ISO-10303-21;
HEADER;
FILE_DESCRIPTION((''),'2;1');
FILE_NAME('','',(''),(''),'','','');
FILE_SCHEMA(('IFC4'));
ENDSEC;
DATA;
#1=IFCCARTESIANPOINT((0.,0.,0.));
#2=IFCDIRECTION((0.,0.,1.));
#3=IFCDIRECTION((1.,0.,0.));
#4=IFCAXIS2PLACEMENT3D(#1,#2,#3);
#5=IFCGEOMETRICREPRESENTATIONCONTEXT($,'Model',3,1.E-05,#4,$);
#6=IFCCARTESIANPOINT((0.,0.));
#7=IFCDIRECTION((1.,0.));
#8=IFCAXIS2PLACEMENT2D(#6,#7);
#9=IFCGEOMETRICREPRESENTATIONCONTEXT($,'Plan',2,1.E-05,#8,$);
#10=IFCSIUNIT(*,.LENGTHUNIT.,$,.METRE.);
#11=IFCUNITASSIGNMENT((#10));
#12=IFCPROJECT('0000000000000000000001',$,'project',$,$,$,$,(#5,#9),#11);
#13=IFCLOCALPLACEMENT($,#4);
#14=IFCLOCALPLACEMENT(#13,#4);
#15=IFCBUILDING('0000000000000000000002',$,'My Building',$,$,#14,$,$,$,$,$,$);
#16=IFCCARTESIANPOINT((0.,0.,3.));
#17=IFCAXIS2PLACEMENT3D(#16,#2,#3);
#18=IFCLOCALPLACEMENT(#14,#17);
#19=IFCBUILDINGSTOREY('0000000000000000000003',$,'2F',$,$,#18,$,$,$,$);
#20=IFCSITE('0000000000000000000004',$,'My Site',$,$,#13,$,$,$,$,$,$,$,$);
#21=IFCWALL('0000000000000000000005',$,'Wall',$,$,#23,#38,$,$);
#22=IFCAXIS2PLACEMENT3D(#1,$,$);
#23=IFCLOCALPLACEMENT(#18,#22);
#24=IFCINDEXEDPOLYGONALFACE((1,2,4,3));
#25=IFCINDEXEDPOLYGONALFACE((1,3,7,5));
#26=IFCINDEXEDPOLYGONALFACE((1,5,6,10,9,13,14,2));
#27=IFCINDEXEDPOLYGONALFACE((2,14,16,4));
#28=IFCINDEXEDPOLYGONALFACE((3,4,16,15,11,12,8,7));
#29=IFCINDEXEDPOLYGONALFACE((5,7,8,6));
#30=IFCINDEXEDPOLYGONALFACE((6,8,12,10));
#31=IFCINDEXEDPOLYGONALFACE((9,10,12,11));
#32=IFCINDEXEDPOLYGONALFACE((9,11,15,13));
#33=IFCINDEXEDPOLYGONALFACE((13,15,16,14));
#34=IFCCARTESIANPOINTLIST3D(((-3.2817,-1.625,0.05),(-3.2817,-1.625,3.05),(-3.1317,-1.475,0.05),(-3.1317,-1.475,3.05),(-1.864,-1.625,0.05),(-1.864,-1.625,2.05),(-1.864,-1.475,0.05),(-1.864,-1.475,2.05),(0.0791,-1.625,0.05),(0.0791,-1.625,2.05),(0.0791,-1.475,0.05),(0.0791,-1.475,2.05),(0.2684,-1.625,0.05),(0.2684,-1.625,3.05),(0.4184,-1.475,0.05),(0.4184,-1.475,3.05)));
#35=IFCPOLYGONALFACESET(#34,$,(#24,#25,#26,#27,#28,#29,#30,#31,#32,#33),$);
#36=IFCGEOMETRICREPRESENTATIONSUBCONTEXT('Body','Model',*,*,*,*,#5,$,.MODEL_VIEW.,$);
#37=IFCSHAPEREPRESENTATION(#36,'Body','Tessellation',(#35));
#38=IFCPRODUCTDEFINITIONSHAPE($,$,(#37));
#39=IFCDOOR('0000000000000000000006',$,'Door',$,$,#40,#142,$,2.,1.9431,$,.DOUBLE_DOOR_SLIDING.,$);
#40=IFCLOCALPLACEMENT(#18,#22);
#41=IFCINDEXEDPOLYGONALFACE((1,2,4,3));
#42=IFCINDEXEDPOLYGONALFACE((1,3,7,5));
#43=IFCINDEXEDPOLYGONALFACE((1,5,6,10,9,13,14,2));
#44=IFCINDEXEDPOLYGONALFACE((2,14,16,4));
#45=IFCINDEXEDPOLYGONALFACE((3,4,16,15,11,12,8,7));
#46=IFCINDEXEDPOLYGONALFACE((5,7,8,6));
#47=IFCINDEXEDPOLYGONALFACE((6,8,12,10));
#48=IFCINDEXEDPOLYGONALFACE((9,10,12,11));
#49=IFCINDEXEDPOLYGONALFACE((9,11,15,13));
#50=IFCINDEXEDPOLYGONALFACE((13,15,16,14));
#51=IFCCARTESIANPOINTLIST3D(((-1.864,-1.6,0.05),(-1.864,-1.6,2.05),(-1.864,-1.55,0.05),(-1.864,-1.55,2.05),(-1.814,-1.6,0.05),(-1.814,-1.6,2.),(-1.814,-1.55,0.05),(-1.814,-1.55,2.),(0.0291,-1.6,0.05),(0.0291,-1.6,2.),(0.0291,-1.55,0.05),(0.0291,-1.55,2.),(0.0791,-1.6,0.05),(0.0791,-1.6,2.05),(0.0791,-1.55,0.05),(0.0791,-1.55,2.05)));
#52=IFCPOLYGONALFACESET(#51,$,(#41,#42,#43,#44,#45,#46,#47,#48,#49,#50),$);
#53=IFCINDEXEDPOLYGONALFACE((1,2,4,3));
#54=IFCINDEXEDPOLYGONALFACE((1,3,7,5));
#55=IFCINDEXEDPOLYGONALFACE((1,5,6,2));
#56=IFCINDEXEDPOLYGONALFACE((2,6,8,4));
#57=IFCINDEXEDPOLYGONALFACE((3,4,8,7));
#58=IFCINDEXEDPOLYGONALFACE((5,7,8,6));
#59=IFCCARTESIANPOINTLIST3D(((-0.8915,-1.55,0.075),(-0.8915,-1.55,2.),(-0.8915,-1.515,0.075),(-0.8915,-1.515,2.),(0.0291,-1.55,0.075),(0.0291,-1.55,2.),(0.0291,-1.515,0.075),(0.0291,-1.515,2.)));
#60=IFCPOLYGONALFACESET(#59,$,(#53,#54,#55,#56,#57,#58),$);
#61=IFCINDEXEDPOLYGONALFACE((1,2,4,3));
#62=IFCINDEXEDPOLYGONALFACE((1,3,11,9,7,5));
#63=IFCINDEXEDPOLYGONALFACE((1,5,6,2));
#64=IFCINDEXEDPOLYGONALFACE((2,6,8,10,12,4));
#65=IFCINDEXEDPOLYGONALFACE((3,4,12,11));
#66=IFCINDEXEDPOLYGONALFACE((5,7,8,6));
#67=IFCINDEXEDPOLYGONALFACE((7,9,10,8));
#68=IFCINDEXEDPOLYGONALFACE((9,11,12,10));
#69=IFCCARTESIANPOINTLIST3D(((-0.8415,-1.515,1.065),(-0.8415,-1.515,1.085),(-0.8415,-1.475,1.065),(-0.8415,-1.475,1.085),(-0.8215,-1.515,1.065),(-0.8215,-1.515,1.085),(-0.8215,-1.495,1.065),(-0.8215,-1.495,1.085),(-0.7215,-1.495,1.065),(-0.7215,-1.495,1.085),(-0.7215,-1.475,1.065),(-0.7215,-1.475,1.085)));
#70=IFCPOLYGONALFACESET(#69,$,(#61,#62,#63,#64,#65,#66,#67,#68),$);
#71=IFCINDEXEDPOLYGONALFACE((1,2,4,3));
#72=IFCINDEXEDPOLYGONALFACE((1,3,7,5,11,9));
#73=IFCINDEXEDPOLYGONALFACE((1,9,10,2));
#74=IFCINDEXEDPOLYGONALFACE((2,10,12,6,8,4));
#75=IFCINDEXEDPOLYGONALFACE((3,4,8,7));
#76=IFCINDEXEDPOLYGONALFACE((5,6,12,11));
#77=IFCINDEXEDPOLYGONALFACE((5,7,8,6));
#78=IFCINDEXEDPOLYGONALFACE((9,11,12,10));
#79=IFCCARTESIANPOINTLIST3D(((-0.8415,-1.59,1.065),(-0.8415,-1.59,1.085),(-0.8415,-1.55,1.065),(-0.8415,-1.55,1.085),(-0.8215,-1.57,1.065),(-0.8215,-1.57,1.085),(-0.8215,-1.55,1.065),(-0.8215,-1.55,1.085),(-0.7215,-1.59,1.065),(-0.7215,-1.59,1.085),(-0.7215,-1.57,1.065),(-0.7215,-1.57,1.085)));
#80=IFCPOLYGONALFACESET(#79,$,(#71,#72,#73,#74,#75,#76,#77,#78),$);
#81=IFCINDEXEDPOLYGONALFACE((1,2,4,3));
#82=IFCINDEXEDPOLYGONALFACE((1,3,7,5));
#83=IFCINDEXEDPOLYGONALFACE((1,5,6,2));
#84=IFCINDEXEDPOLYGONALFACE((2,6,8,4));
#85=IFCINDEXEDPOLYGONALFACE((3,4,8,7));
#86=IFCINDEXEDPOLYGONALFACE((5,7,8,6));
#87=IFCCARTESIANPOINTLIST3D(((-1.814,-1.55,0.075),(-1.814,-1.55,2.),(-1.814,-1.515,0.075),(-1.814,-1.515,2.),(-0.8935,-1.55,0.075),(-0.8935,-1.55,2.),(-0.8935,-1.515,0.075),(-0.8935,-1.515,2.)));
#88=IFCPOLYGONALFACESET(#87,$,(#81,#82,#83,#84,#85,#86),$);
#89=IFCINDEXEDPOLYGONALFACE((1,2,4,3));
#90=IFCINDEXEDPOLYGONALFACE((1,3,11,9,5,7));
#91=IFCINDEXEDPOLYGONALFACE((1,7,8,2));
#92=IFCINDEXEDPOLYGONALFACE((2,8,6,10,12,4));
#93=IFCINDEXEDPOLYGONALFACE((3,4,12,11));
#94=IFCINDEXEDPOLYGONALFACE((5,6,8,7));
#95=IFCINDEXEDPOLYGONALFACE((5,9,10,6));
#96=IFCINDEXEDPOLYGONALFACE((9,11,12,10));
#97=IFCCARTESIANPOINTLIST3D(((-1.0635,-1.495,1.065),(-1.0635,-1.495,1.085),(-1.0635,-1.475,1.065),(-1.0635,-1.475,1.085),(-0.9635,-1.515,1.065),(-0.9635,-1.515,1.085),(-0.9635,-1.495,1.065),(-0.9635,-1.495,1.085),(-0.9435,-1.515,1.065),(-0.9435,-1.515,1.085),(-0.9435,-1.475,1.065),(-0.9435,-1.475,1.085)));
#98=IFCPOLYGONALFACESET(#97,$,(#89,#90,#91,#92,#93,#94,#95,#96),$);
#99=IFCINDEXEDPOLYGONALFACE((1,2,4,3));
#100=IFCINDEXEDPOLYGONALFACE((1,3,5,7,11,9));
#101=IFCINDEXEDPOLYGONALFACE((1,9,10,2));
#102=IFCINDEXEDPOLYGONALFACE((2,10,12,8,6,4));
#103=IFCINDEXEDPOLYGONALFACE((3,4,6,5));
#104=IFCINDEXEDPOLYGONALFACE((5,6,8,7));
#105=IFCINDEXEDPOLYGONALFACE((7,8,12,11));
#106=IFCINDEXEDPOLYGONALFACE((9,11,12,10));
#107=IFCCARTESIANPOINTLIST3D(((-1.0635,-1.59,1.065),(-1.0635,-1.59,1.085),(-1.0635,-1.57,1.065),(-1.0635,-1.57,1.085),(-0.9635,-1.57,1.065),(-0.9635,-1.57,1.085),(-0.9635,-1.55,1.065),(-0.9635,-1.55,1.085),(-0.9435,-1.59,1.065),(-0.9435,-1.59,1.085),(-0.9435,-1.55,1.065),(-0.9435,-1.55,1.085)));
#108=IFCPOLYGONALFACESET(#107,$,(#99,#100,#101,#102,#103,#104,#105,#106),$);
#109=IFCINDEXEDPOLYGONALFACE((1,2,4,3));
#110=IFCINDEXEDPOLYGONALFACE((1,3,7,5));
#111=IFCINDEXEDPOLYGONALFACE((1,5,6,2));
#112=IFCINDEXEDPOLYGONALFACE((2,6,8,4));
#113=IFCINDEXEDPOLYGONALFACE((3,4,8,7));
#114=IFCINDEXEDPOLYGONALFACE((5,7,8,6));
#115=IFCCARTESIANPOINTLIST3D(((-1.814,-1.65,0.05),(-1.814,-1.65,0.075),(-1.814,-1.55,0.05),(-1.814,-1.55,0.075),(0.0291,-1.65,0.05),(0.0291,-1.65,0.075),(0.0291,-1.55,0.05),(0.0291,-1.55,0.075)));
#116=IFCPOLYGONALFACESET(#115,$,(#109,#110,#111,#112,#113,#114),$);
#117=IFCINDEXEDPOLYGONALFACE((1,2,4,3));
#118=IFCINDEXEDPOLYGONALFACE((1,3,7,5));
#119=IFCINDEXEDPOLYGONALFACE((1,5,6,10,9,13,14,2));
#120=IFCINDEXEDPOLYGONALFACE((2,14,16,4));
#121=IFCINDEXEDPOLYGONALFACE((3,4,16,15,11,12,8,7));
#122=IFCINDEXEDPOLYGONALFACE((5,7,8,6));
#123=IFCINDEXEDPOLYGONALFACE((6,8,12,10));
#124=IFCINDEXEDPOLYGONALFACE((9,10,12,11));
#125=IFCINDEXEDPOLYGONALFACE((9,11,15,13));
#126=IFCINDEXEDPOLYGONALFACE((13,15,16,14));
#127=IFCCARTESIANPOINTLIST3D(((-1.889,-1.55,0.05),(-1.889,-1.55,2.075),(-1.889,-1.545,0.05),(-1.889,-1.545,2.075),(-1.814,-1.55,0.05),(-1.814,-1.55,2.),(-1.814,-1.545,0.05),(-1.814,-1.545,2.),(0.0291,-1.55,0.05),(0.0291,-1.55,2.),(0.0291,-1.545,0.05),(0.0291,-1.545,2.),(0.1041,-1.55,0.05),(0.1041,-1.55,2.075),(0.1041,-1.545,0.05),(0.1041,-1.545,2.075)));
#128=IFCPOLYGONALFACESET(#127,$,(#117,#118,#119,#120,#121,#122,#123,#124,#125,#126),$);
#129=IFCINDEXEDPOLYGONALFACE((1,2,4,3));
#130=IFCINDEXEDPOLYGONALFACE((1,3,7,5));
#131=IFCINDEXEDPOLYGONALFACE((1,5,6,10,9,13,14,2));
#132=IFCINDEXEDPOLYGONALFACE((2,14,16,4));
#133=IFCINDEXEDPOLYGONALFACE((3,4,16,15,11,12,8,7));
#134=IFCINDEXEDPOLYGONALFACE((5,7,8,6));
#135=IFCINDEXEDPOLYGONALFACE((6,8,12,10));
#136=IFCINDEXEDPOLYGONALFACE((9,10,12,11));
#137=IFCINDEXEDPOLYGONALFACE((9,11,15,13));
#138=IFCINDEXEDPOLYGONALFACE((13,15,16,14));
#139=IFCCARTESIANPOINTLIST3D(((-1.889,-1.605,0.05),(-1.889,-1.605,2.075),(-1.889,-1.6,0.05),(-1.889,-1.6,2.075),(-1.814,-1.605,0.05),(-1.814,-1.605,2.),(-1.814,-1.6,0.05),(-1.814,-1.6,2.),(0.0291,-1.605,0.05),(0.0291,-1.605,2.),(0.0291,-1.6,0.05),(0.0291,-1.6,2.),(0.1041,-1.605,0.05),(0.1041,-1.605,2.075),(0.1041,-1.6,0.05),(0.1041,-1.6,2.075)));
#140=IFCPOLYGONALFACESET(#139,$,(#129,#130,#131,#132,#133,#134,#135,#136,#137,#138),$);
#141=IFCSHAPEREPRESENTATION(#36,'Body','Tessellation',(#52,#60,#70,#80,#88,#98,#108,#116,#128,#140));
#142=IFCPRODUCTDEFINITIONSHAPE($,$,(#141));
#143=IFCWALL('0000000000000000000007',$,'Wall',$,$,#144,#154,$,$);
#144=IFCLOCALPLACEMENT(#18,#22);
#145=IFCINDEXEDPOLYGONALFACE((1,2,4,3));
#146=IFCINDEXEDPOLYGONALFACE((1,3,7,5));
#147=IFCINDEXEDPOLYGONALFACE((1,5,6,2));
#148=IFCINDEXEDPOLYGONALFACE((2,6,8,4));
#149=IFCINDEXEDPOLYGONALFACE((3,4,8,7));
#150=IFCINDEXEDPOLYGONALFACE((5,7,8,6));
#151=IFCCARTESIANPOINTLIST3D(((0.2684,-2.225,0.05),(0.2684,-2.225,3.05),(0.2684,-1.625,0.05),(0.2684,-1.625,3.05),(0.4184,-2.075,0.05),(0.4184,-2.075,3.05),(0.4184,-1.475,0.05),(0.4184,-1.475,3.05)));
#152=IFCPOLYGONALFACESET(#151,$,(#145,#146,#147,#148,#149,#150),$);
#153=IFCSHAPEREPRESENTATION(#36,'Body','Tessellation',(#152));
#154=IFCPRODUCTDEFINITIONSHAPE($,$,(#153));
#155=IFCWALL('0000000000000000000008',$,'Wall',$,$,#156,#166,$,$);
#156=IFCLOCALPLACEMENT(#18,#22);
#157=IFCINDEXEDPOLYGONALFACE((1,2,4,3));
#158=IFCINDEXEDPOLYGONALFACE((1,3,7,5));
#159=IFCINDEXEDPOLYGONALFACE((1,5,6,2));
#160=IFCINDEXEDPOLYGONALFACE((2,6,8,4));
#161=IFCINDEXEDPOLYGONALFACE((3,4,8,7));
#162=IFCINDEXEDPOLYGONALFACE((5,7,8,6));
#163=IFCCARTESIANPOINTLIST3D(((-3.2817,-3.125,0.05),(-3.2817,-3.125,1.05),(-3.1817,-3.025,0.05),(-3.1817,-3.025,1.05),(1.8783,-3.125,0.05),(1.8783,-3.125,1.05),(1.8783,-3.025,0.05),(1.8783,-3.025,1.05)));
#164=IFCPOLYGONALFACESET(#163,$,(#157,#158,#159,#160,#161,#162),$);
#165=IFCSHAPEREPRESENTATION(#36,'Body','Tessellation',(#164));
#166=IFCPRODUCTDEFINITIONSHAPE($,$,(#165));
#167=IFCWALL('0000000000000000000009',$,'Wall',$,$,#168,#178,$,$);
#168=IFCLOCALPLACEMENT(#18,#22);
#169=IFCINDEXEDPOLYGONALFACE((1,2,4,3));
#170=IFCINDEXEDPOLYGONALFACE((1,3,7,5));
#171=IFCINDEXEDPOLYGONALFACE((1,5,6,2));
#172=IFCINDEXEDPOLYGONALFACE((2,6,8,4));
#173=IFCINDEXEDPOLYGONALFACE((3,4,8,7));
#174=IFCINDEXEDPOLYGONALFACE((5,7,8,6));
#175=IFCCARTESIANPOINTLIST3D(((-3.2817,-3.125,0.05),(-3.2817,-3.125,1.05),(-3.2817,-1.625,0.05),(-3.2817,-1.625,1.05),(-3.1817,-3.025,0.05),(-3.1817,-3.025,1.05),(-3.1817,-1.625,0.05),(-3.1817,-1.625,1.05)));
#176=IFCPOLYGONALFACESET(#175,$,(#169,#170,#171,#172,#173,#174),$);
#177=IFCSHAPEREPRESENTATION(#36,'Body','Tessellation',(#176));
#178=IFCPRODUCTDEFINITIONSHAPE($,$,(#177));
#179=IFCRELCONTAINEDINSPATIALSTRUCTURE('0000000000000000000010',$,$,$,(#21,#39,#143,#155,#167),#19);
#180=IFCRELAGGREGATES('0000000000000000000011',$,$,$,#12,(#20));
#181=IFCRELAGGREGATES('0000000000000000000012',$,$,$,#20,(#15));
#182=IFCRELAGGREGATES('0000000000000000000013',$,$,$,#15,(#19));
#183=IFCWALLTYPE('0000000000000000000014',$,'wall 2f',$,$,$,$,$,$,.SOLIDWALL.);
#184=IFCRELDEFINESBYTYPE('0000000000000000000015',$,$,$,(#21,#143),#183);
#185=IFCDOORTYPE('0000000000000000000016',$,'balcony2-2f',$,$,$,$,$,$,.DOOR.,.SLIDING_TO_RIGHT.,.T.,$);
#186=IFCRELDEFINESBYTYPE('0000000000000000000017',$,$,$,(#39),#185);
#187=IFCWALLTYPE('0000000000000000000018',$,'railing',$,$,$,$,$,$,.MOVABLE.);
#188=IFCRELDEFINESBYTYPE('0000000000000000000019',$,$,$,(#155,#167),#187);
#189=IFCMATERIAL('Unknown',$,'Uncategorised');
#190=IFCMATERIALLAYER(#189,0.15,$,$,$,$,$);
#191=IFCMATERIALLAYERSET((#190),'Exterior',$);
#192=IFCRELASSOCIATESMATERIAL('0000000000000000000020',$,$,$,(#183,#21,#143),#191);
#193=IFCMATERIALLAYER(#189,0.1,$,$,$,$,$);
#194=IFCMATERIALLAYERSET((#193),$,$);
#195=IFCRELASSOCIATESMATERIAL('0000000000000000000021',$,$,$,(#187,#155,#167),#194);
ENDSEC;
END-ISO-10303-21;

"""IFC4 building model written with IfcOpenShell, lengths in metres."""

from ifc_helpers import new_model, entity, si_unit, frame, origin_with_axes, origin_2d_with_axis, place, context, subcontext, project, spatial, line, indexed_curve, outline, extrude, shape, source, transform, mapped, material, layer, layer_set, layer_usage, type_object, type_shapes, element, fill, save


model = new_model("IFC4")

# Units and contexts
model_context = context("Model", 3, precision=1e-05, world=origin_with_axes())
plan_context = context("Plan", 2, precision=1e-05, world=origin_2d_with_axis())
body_context_1 = subcontext(model_context, "Body", "Model", "MODEL_VIEW")
body_context_2 = subcontext(plan_context, "Body", "Plan", "PLAN_VIEW")
ifc_project = project(units=[si_unit("LENGTHUNIT", "METRE")], contexts=[model_context, plan_context])

# Site, building, storey
site_placement = place(None, origin_with_axes())
site = spatial("IfcSite", under=ifc_project, at=site_placement, Name="My Site")
building_placement = place(site_placement, origin_with_axes())
building = spatial("IfcBuilding", under=site, at=building_placement, Name="My Building")
storey_placement = place(building_placement, frame((0.0, 0.0, 3.0), z_axis=(0.0, 0.0, 1.0), x_axis=(1.0, 0.0, 0.0)))
storey = spatial("IfcBuildingStorey", under=building, at=storey_placement, Name="2F")

# Shared definitions
ifc_material = material(Name="Unknown", Category="Uncategorised")
ifc_layer_1 = layer(ifc_material, 0.15)
ifc_layer_set_1 = layer_set([ifc_layer_1], Name="Exterior")
wall_type_1 = type_object("IfcWallType", Name="wall 2f", PredefinedType="SOLIDWALL", material=ifc_layer_set_1)

# Wall, opening, door
ifc_layer_usage_1 = layer_usage(ifc_layer_set_1, "AXIS2", "POSITIVE", 0.0)
wall_1_placement = place(storey_placement, frame((-3.2817, -1.625, 0.05), z_axis=(0.0, 0.0, 1.0), x_axis=(1.0, 0.0, 0.0)))
wall_1 = element("IfcWall", 1, at=wall_1_placement, inside=storey, type_object=wall_type_1, material=ifc_layer_usage_1, Name="Wall", context=body_context_1, shape_type="SweptSolid", body=[
    extrude(outline(indexed_curve([(0.0, 0.0), (0.15, 0.15), (3.7, 0.15), (3.55, 0.0)], segments=[line(1, 2, 3, 4, 1)])), origin_with_axes(), (0.0, 0.0, 1.0), 3.0),
])
shared_shape_1 = source(origin_with_axes(), body_context_1, "Body", "SweptSolid", [
    extrude(outline(indexed_curve([(0.0, 0.0), (1.9431, 0.0), (1.9431, 2.0), (0.0, 2.0)], segments=[line(1, 2, 3, 4, 1)])), frame((0.0, -0.6, 0.0), z_axis=(0.0, -1.0, 0.0), x_axis=(1.0, 0.0, 0.0)), (0.0, 0.0, -1.0), 1.2),
])
opening_1_placement = place(wall_1_placement, frame((3.3607, 0.075, 0.0), z_axis=(0.0, 0.0, 1.0), x_axis=(-1.0, 0.0, 0.0)))
opening_1 = element("IfcOpeningElement", 2, at=opening_1_placement, cuts=wall_1, PredefinedType="OPENING", context=body_context_1, shape_type="MappedRepresentation", body=[
    mapped(shared_shape_1, transform((0.0, 0.0, 0.0), x_axis=(1.0, 0.0, 0.0), y_axis=(0.0, 1.0, 0.0), z_axis=(0.0, 0.0, 1.0), scale=1.0)),
])
door_type_1 = type_object("IfcDoorType", Name="balcony2-2f", OperationType="SLIDING_TO_RIGHT", ParameterTakesPrecedence=True, PredefinedType="DOOR")
shared_shape_2 = source(origin_with_axes(), body_context_1, "Body", "SweptSolid", [
    extrude(outline(indexed_curve([(0.0, 0.0), (0.0, 2.0), (1.9431, 2.0), (1.9431, 0.0), (1.8931, 0.0), (1.8931, 1.95), (0.05, 1.95), (0.05, 0.0)], segments=[line(1, 2, 3, 4, 5, 6, 7, 8, 1)])), frame((0.0, 0.0, 0.0), z_axis=(0.0, -1.0, 0.0), x_axis=(1.0, 0.0, 0.0)), (0.0, 0.0, -1.0), 0.05),
    extrude(outline(indexed_curve([(0.0, 0.0), (0.9205, 0.0), (0.9205, 0.035), (0.0, 0.035)], segments=[line(1, 2, 3, 4, 1)])), frame((0.05, -0.035, 0.025), z_axis=(0.0, 0.0, 1.0), x_axis=(1.0, 0.0, 0.0)), (0.0, 0.0, 1.0), 1.925),
    extrude(outline(indexed_curve([(0.0, 0.0), (0.0, -0.04), (-0.12, -0.04), (-0.12, -0.02), (-0.02, -0.02), (-0.02, 0.0)], segments=[line(1, 2, 3, 4, 5, 6, 1)])), frame((0.9205, -0.035, 1.015), z_axis=(0.0, 0.0, 1.0), x_axis=(1.0, 0.0, 0.0)), (0.0, 0.0, 1.0), 0.02),
    extrude(outline(indexed_curve([(0.0, 0.0), (0.0, 0.04), (-0.12, 0.04), (-0.12, 0.02), (-0.02, 0.02), (-0.02, 0.0)], segments=[line(1, 2, 3, 4, 5, 6, 1)])), frame((0.9205, 0.0, 1.015), z_axis=(0.0, 0.0, 1.0), x_axis=(1.0, 0.0, 0.0)), (0.0, 0.0, 1.0), 0.02),
    extrude(outline(indexed_curve([(0.0, 0.0), (-0.9205, 0.0), (-0.9205, 0.035), (0.0, 0.035)], segments=[line(1, 2, 3, 4, 1)])), frame((1.8931, -0.035, 0.025), z_axis=(0.0, 0.0, 1.0), x_axis=(1.0, 0.0, 0.0)), (0.0, 0.0, 1.0), 1.925),
    extrude(outline(indexed_curve([(0.0, 0.0), (0.0, -0.04), (0.12, -0.04), (0.12, -0.02), (0.02, -0.02), (0.02, 0.0)], segments=[line(1, 2, 3, 4, 5, 6, 1)])), frame((1.0225, -0.035, 1.015), z_axis=(0.0, 0.0, 1.0), x_axis=(1.0, 0.0, 0.0)), (0.0, 0.0, 1.0), 0.02),
    extrude(outline(indexed_curve([(0.0, 0.0), (0.0, 0.04), (0.12, 0.04), (0.12, 0.02), (0.02, 0.02), (0.02, 0.0)], segments=[line(1, 2, 3, 4, 5, 6, 1)])), frame((1.0225, 0.0, 1.015), z_axis=(0.0, 0.0, 1.0), x_axis=(1.0, 0.0, 0.0)), (0.0, 0.0, 1.0), 0.02),
    extrude(outline(indexed_curve([(0.0, 0.0), (1.8431, 0.0), (1.8431, 0.1), (0.0, 0.1)], segments=[line(1, 2, 3, 4, 1)])), frame((0.05, 0.0, 0.0), z_axis=(0.0, 0.0, 1.0), x_axis=(1.0, 0.0, 0.0)), (0.0, 0.0, 1.0), 0.025),
    extrude(outline(indexed_curve([(0.0, 0.0), (0.0, 2.025), (1.9931, 2.025), (1.9931, 0.0), (1.9181, 0.0), (1.9181, 1.95), (0.075, 1.95), (0.075, 0.0)], segments=[line(1, 2, 3, 4, 5, 6, 7, 8, 1)])), frame((-0.025, -0.005, 0.0), z_axis=(0.0, -1.0, 0.0), x_axis=(1.0, 0.0, 0.0)), (0.0, 0.0, -1.0), 0.005),
    extrude(outline(indexed_curve([(0.0, 0.0), (0.0, 2.025), (1.9931, 2.025), (1.9931, 0.0), (1.9181, 0.0), (1.9181, 1.95), (0.075, 1.95), (0.075, 0.0)], segments=[line(1, 2, 3, 4, 5, 6, 7, 8, 1)])), frame((-0.025, 0.05, 0.0), z_axis=(0.0, -1.0, 0.0), x_axis=(1.0, 0.0, 0.0)), (0.0, 0.0, -1.0), 0.005),
])
shared_shape_3 = source(origin_with_axes(), body_context_2, "Body", "Curve2D", [
    entity("IfcIndexedPolyCurve", entity("IfcCartesianPointList2D", [[0.0, 0.0], [0.05, 0.0], [0.05, 0.05], [0.0, 0.05]]), [entity("IfcLineIndex", [1, 2, 3, 4, 1])]),
    entity("IfcIndexedPolyCurve", entity("IfcCartesianPointList2D", [[1.9431, 0.0], [1.8931, 0.0], [1.8931, 0.05], [1.9431, 0.05]]), [entity("IfcLineIndex", [1, 2, 3, 4, 1])]),
    entity("IfcIndexedPolyCurve", entity("IfcCartesianPointList2D", [[-0.4108, -0.035], [0.5108, -0.035], [0.5108, 0.0], [-0.4108, 0.0]]), [entity("IfcLineIndex", [1, 2, 3, 4, 1])]),
    entity("IfcIndexedPolyCurve", entity("IfcCartesianPointList2D", [[2.3538, -0.035], [1.4323, -0.035], [1.4323, 0.0], [2.3538, 0.0]]), [entity("IfcLineIndex", [1, 2, 3, 4, 1])]),
])
type_shapes(door_type_1, [shared_shape_2, shared_shape_3])
door_1_placement = place(opening_1_placement, origin_with_axes())
door_1 = element("IfcDoor", 3, at=door_1_placement, inside=storey, type_object=door_type_1, Name="Door", OperationType="DOUBLE_DOOR_SLIDING", OverallHeight=2.0, OverallWidth=1.9431, shapes=[
    shape(body_context_1, "Body", "MappedRepresentation", [mapped(shared_shape_2, transform((0.0, 0.0, 0.0), x_axis=(1.0, 0.0, 0.0), y_axis=(0.0, 1.0, 0.0), z_axis=(0.0, 0.0, 1.0), scale=1.0))]),
    shape(body_context_2, "Body", "MappedRepresentation", [mapped(shared_shape_3, transform((0.0, 0.0, 0.0), x_axis=(1.0, 0.0, 0.0), y_axis=(0.0, 1.0, 0.0), z_axis=(0.0, 0.0, 1.0), scale=1.0))]),
])
fill(opening_1, door_1)

# Walls
ifc_layer_usage_2 = layer_usage(ifc_layer_set_1, "AXIS2", "POSITIVE", 0.0)
wall_2_placement = place(storey_placement, frame((0.2684, -1.625, 0.05), z_axis=(0.0, 0.0, 1.0), x_axis=(0.0, -1.0, 0.0)))
element("IfcWall", 4, at=wall_2_placement, inside=storey, type_object=wall_type_1, material=ifc_layer_usage_2, Name="Wall", context=body_context_1, shape_type="SweptSolid", body=[
    extrude(outline(indexed_curve([(0.0, 0.0), (-0.15, 0.15), (0.45, 0.15), (0.6, 0.0)], segments=[line(1, 2, 3, 4, 1)])), origin_with_axes(), (0.0, 0.0, 1.0), 3.0),
])
ifc_layer_2 = layer(ifc_material, 0.1)
ifc_layer_set_2 = layer_set([ifc_layer_2])
ifc_layer_usage_3 = layer_usage(ifc_layer_set_2, "AXIS2", "POSITIVE", 0.0)
wall_type_2 = type_object("IfcWallType", Name="railing", PredefinedType="MOVABLE", material=ifc_layer_set_2)
wall_3_placement = place(storey_placement, frame((1.8783, -3.025, 0.05), z_axis=(0.0, 0.0, 1.0), x_axis=(-1.0, 0.0, 0.0)))
element("IfcWall", 5, at=wall_3_placement, inside=storey, type_object=wall_type_2, material=ifc_layer_usage_3, Name="Wall", context=body_context_1, shape_type="SweptSolid", body=[
    extrude(outline(indexed_curve([(0.0, 0.0), (0.0, 0.1), (5.16, 0.1), (5.06, 0.0)], segments=[line(1, 2, 3, 4, 1)])), origin_with_axes(), (0.0, 0.0, 1.0), 1.0),
])
ifc_layer_usage_4 = layer_usage(ifc_layer_set_2, "AXIS2", "POSITIVE", 0.0)
wall_4_placement = place(storey_placement, frame((-3.2817, -1.625, 0.05), z_axis=(0.0, 0.0, 1.0), x_axis=(0.0, -1.0, 0.0)))
element("IfcWall", 6, at=wall_4_placement, inside=storey, type_object=wall_type_2, material=ifc_layer_usage_4, Name="Wall", context=body_context_1, shape_type="SweptSolid", body=[
    extrude(outline(indexed_curve([(0.0, 0.0), (0.0, 0.1), (1.4, 0.1), (1.5, 0.0)], segments=[line(1, 2, 3, 4, 1)])), origin_with_axes(), (0.0, 0.0, 1.0), 1.0),
])

save(model, "model.ifc")
